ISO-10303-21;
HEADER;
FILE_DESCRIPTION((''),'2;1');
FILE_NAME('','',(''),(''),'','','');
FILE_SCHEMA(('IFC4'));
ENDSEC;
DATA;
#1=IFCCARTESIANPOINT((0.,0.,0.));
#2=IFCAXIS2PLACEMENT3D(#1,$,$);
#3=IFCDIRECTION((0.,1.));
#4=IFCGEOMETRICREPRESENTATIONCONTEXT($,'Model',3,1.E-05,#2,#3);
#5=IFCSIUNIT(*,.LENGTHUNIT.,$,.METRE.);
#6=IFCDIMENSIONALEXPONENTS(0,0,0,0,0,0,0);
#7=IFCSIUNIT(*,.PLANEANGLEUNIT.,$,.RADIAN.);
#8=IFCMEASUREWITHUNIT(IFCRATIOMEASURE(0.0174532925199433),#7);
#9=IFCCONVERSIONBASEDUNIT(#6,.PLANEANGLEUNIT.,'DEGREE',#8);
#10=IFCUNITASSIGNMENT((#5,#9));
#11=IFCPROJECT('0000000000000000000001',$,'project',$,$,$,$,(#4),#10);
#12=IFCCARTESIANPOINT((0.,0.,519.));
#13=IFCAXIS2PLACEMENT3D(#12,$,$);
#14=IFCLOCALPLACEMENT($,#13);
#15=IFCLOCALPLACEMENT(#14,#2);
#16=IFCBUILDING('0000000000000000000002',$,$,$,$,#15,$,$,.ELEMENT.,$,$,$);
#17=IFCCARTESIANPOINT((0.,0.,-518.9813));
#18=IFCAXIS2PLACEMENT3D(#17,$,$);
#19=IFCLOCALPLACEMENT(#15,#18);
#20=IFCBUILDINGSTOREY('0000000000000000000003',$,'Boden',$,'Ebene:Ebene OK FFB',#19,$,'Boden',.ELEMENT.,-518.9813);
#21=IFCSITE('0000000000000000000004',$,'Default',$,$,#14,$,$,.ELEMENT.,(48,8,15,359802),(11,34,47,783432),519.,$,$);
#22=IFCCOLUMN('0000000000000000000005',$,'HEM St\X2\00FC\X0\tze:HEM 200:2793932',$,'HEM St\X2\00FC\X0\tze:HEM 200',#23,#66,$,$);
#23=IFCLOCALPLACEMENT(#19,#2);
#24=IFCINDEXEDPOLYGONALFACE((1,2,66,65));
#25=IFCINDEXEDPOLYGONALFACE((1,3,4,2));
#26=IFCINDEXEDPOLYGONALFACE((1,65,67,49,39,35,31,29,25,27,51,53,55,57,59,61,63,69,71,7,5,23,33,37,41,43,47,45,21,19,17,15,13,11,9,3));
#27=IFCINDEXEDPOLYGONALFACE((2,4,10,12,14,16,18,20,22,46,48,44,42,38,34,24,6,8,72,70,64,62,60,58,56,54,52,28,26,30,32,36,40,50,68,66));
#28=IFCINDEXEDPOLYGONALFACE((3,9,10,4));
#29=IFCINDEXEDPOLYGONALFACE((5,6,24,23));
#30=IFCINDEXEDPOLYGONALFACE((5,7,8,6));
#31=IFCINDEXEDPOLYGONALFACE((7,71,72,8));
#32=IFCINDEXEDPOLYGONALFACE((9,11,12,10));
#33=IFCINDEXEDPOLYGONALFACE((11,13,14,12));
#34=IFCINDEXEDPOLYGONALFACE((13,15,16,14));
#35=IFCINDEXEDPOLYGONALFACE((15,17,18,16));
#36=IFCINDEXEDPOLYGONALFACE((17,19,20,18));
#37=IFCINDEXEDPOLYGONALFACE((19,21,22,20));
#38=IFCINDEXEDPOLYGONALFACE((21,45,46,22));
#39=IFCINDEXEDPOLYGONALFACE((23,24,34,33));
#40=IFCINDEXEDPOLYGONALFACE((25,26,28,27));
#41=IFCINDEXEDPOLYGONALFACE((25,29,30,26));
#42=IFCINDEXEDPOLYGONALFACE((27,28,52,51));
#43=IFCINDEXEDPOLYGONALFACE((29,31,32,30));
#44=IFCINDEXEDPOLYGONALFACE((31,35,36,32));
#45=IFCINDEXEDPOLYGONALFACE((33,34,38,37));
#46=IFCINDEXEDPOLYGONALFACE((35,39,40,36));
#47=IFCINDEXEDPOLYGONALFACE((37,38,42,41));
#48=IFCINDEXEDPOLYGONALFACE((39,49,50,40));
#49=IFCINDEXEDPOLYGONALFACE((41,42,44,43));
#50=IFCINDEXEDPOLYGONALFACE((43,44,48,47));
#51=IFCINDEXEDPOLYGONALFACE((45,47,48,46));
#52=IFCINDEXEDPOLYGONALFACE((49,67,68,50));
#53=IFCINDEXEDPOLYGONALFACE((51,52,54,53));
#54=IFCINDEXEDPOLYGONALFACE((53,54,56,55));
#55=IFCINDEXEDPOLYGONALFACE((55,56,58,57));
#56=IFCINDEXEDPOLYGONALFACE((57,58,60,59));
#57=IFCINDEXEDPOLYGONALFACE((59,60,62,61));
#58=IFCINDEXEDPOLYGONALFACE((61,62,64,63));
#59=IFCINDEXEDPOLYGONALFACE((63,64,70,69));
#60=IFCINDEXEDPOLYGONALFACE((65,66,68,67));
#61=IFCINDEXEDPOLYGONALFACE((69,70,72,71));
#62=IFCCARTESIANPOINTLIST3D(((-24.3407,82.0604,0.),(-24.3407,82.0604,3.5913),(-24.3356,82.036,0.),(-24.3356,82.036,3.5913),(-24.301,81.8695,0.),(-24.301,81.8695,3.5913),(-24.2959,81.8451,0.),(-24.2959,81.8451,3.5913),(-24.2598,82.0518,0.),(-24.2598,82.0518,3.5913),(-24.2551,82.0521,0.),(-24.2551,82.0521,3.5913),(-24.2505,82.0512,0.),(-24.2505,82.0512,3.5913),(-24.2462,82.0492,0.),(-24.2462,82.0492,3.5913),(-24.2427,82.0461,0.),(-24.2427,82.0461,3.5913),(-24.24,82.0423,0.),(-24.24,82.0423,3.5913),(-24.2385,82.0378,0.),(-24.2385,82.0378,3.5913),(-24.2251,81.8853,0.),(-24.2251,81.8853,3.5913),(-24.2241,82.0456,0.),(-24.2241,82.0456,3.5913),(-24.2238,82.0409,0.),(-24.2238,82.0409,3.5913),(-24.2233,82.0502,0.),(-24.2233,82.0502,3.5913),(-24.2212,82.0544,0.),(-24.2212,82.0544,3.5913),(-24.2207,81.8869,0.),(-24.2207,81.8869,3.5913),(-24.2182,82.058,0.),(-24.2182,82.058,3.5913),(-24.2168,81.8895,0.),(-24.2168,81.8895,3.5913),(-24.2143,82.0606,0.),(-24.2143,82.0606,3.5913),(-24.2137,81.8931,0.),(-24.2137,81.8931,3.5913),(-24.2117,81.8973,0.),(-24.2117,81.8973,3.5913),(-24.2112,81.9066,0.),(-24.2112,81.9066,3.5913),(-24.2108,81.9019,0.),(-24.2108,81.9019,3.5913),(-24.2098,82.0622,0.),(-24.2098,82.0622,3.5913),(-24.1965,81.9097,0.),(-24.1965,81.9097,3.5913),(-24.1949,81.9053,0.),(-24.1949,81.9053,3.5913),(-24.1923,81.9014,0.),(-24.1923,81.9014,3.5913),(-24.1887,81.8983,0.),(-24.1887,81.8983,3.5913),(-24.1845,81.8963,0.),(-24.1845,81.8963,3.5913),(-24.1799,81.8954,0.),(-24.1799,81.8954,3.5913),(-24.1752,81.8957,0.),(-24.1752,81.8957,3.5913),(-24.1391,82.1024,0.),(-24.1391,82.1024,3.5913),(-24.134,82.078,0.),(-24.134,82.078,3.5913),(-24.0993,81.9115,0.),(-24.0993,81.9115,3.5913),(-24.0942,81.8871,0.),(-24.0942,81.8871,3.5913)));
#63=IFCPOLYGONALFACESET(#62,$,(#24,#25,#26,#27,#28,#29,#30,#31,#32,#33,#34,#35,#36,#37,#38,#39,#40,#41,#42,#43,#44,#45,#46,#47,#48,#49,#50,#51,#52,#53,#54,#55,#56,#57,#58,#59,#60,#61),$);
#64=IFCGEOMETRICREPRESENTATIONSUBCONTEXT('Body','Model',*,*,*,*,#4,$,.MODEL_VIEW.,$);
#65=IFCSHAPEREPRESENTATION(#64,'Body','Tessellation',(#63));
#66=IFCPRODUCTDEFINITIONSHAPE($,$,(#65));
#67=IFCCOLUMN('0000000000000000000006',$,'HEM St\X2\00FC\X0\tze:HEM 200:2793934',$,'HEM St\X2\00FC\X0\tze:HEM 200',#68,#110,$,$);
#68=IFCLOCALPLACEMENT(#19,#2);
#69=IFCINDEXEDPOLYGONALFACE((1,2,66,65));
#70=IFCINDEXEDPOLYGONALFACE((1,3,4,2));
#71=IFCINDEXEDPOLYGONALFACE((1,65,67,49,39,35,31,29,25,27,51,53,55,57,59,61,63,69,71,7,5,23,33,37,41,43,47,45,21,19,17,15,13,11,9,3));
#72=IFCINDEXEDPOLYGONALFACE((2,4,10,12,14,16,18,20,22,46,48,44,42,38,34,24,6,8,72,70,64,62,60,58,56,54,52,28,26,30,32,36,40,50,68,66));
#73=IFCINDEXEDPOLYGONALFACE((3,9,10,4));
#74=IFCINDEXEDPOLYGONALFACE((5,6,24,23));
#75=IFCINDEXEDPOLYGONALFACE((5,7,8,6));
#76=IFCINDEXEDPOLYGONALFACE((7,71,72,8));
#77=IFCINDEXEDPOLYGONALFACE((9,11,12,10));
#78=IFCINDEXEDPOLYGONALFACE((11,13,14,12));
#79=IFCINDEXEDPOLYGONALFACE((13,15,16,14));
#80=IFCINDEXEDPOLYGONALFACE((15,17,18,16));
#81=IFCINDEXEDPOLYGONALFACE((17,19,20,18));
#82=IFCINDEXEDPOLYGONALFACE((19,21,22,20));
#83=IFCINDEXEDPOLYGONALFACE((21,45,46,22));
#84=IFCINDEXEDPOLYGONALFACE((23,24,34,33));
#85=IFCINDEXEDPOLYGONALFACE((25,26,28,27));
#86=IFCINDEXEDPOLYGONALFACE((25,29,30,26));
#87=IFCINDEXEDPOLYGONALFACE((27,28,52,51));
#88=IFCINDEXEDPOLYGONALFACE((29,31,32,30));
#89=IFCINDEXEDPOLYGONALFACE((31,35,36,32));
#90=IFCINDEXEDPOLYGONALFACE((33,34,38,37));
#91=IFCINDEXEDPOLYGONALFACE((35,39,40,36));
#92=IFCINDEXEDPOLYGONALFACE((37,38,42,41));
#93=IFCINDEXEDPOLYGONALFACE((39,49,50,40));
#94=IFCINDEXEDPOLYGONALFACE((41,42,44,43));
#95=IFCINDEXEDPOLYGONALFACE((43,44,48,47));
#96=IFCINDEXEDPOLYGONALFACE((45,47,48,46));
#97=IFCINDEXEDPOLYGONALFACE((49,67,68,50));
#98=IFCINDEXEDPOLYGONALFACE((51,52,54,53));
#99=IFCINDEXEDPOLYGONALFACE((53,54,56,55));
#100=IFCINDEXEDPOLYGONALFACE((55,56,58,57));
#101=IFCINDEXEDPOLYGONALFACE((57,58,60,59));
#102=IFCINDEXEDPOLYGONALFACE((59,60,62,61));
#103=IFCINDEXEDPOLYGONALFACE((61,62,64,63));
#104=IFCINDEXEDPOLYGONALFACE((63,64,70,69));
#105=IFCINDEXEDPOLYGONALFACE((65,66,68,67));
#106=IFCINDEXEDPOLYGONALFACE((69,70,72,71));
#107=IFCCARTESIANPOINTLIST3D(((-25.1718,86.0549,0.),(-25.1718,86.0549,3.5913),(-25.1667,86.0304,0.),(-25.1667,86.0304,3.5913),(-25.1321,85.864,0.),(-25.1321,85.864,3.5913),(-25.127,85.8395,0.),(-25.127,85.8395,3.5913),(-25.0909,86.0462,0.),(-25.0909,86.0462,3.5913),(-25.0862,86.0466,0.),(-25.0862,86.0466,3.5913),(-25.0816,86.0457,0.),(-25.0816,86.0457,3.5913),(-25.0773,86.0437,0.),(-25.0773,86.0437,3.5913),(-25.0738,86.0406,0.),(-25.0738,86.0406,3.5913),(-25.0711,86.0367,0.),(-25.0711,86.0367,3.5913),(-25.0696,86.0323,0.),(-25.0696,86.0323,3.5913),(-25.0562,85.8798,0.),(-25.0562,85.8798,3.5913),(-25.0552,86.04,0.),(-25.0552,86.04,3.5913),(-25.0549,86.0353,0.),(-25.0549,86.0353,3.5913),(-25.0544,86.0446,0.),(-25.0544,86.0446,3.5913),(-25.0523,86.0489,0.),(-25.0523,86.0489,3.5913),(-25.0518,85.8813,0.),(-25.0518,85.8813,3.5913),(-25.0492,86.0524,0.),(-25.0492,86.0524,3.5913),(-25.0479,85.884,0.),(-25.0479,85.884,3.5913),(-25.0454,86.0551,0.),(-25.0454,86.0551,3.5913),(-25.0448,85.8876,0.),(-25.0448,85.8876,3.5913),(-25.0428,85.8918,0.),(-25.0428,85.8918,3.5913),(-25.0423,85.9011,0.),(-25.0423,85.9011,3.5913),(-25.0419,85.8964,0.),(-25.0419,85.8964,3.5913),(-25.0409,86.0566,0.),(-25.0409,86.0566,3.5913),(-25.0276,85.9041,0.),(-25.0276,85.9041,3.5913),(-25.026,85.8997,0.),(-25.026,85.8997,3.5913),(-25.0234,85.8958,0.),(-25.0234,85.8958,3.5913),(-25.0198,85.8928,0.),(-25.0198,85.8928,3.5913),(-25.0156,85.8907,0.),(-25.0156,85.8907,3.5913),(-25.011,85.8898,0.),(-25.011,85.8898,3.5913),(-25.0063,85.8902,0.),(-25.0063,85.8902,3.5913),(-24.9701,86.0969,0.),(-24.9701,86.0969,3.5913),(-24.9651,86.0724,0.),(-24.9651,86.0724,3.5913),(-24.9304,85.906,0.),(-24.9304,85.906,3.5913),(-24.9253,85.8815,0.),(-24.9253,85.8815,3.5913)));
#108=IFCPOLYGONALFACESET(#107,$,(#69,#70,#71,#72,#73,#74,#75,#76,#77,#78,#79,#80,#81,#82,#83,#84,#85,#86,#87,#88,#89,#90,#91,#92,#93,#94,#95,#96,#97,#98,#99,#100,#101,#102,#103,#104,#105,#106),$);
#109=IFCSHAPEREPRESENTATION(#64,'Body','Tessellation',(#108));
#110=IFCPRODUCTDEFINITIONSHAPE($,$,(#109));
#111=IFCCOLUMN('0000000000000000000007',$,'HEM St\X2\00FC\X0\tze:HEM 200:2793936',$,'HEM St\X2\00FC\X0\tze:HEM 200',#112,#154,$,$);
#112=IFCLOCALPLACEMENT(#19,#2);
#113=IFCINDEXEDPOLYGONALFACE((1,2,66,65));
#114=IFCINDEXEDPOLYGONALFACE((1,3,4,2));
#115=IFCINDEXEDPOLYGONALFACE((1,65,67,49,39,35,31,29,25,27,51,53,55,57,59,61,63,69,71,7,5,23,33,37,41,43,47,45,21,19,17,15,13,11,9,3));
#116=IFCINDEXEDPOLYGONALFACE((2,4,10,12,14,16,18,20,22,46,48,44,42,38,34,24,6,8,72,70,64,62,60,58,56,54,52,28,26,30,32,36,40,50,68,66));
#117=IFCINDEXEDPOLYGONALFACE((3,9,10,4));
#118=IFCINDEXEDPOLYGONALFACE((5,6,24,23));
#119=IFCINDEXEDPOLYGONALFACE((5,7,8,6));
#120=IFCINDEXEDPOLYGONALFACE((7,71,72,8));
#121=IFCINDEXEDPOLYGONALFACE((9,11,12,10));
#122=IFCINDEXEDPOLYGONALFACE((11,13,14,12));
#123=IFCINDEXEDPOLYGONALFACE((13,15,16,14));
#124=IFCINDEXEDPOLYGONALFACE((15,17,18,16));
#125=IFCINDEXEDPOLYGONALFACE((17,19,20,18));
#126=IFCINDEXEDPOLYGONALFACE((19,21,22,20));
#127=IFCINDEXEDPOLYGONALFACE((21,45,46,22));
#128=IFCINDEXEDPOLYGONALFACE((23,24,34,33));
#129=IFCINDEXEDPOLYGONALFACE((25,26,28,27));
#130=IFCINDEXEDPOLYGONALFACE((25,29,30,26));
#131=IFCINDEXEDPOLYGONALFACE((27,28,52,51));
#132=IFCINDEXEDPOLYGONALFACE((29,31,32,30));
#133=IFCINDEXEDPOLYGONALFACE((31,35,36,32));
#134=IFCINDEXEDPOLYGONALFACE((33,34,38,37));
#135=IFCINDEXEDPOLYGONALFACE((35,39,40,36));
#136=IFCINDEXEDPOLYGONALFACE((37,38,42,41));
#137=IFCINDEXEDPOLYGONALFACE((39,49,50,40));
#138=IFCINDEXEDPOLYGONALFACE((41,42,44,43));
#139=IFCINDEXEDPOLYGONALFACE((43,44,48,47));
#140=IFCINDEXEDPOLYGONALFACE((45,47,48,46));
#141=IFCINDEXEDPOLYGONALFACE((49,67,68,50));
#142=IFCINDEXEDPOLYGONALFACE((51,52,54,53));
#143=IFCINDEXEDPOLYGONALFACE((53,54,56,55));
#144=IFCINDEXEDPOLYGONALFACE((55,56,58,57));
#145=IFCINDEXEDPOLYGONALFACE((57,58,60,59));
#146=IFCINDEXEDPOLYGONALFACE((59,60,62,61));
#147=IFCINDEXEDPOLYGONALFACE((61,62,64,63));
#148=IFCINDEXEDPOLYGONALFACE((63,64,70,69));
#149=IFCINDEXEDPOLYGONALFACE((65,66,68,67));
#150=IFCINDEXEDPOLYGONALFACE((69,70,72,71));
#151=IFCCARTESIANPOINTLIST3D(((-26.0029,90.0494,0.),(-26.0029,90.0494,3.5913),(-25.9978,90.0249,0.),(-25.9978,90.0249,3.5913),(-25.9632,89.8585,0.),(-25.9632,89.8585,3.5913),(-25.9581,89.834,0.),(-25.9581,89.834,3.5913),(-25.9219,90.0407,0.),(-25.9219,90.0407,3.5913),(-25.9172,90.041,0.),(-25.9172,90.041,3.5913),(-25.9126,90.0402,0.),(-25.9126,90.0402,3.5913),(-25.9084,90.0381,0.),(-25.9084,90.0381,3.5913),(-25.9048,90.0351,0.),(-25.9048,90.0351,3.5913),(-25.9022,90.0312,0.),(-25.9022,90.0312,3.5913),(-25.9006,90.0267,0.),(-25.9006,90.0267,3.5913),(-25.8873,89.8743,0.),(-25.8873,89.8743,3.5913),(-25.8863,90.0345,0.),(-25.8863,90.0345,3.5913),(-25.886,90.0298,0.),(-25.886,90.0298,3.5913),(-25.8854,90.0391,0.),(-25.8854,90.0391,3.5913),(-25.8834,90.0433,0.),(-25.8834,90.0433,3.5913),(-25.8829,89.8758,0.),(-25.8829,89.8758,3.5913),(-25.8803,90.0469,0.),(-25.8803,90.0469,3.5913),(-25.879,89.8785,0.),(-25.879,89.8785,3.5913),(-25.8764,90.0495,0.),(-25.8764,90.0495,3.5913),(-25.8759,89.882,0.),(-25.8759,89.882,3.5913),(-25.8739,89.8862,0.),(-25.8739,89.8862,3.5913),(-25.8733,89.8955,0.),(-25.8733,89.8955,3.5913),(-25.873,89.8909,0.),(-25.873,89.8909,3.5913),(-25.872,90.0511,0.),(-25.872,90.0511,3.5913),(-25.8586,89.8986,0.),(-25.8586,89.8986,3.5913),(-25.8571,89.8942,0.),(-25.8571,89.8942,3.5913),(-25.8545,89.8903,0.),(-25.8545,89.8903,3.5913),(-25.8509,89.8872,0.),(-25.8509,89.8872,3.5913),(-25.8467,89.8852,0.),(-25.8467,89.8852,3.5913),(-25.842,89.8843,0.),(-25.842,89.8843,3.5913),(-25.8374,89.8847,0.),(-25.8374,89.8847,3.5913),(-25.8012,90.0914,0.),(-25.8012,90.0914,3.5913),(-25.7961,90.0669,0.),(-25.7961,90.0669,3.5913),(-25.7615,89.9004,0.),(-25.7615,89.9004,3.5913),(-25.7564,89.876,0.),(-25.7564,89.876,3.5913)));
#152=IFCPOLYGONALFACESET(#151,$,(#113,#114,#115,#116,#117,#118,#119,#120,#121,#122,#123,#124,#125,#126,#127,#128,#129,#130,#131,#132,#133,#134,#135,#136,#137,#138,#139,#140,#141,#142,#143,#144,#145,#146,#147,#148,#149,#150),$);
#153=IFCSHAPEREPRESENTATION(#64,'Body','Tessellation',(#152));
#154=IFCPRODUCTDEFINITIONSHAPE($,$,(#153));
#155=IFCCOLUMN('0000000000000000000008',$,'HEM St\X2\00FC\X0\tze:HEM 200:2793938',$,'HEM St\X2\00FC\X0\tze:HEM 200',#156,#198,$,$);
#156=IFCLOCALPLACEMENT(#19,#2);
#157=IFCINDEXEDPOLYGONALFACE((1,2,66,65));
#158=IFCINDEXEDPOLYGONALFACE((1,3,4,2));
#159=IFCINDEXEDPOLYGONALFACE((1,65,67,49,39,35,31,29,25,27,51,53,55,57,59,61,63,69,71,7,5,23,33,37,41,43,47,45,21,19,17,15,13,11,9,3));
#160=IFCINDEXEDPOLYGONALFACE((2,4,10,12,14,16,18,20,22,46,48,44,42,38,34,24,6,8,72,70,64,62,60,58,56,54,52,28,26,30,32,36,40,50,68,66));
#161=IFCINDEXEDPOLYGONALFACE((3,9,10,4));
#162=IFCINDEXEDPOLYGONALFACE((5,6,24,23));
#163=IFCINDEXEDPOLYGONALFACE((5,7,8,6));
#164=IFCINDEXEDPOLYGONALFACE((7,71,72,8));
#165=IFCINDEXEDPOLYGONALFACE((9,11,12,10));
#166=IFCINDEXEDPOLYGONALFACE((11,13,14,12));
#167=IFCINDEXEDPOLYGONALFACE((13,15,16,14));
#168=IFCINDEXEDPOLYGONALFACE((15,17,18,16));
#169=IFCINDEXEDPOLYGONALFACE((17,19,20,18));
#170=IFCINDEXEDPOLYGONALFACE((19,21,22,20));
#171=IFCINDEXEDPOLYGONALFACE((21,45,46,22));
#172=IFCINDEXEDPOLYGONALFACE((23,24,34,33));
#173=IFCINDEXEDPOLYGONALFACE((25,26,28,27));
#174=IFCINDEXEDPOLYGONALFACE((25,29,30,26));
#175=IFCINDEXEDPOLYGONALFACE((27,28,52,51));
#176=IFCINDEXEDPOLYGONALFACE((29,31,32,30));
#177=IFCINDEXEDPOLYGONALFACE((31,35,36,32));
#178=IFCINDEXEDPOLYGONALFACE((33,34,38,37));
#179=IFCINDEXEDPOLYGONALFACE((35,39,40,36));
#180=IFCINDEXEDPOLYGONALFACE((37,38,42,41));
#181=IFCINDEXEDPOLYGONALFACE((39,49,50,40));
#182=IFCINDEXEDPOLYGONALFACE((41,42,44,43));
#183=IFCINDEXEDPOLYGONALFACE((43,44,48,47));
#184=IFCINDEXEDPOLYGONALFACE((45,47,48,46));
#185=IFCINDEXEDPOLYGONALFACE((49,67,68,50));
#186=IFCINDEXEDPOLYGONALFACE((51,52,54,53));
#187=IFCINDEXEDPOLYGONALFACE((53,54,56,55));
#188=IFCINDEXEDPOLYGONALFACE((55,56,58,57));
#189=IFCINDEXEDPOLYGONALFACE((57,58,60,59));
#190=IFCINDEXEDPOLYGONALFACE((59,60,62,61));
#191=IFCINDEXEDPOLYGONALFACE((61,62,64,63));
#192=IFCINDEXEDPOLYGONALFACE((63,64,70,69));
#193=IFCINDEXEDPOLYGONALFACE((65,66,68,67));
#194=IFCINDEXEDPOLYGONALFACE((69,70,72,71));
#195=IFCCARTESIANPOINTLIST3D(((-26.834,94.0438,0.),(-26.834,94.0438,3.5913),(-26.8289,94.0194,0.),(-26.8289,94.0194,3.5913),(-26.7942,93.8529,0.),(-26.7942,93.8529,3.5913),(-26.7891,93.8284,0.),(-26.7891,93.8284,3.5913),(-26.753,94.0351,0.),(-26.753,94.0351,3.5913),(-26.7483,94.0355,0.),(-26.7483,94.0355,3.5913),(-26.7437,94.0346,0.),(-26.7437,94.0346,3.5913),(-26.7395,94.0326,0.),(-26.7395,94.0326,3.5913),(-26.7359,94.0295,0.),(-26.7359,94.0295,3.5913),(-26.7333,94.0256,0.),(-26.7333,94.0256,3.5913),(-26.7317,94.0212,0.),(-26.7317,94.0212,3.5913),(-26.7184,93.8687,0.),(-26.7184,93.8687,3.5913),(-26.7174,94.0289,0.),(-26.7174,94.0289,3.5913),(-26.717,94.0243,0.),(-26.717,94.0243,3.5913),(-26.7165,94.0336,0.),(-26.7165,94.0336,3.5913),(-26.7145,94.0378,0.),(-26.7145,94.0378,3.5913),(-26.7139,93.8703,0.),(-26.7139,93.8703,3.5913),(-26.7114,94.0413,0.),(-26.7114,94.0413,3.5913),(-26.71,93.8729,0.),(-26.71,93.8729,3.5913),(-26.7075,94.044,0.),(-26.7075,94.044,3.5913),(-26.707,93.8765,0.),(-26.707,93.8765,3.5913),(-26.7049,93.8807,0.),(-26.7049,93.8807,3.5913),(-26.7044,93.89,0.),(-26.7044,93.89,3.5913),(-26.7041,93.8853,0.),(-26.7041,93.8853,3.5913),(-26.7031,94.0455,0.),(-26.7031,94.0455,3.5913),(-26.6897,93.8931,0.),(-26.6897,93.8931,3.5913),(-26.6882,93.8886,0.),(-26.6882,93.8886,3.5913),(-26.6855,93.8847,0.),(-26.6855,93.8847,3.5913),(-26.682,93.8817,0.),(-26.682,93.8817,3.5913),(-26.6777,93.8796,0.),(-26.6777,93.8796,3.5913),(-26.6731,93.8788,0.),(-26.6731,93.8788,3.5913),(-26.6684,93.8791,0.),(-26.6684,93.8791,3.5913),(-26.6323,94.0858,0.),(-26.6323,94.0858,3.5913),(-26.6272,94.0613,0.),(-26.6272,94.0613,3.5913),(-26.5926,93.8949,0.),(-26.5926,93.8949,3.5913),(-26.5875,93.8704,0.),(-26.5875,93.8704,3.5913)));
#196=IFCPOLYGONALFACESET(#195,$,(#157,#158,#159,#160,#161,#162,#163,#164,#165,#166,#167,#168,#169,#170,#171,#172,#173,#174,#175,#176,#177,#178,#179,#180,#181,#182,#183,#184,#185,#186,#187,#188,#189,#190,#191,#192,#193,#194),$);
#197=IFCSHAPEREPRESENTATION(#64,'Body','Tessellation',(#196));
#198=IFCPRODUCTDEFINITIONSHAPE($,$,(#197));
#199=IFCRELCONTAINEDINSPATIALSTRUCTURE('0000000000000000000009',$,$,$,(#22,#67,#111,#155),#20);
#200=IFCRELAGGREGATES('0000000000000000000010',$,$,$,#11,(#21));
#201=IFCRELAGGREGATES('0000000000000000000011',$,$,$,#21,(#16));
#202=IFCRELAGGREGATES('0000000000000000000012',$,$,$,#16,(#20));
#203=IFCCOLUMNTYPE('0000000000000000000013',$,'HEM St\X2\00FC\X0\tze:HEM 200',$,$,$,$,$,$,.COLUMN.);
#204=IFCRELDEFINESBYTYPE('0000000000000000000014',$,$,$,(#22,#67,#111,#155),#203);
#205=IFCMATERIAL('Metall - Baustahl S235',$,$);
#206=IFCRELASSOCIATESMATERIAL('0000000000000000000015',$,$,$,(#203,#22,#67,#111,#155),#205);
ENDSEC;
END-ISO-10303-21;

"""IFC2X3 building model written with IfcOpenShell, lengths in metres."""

from ifc_helpers import new_model, entity, si_unit, converted_unit, direction, frame, frame_2d, origin, place, context, subcontext, project, spatial, polyline, circle_curve, parameter, trimmed, segment, composite_curve, outline, extrude, source, transform, mapped, material, type_object, type_shapes, element, save


model = new_model("IFC2X3")

# Units and contexts
model_context = context("Model", 3, precision=1e-05, world=origin(), true_north=direction((0.0, 1.0)))
body_context = subcontext(model_context, "Body", "Model", "MODEL_VIEW")
ifc_project = project(units=[si_unit("LENGTHUNIT", "METRE"), converted_unit("PLANEANGLEUNIT", "DEGREE", entity("IfcRatioMeasure", 0.0174532925199433), si_unit("PLANEANGLEUNIT", "RADIAN"), dimensions=[0, 0, 0, 0, 0, 0, 0])], contexts=[model_context])

# Site, building, storey
site_placement = place(None, frame((0.0, 0.0, 519.0)))
site = spatial("IfcSite", under=ifc_project, at=site_placement, Name="Default", CompositionType="ELEMENT", RefLatitude=(48, 8, 15, 359802), RefLongitude=(11, 34, 47, 783432), RefElevation=519.0)
building_placement = place(site_placement, origin())
building = spatial("IfcBuilding", under=site, at=building_placement, CompositionType="ELEMENT")
storey_placement = place(building_placement, frame((0.0, 0.0, -518.9813)))
storey = spatial("IfcBuildingStorey", under=building, at=storey_placement, Name="Boden", ObjectType="Ebene:Ebene OK FFB", LongName="Boden", CompositionType="ELEMENT", Elevation=-518.9813)

# Columns
ifc_material = material(Name="Metall - Baustahl S235")
column_type = type_object("IfcColumnType", Name="HEM Stütze:HEM 200", PredefinedType="COLUMN", material=ifc_material)
shared_shape = source(origin(), body_context, "Body", "SweptSolid", [
    extrude(outline(composite_curve([segment(polyline([(0.085, -0.103), (0.11, -0.103)]), True, "CONTINUOUS"), segment(polyline([(0.11, -0.103), (0.11, 0.103)]), True, "CONTINUOUS"), segment(polyline([(0.11, 0.103), (0.085, 0.103)]), True, "CONTINUOUS"), segment(polyline([(0.085, 0.103), (0.085, 0.0255)]), True, "CONTINUOUS"), segment(trimmed(circle_curve(frame_2d((0.067, 0.0255), x_axis=(1.0, 0.0)), 0.018), [parameter(270.0)], [parameter(0.0)], True, "PARAMETER"), False, "CONTINUOUS"), segment(polyline([(0.067, 0.0075), (-0.067, 0.0075)]), True, "CONTINUOUS"), segment(trimmed(circle_curve(frame_2d((-0.067, 0.0255), x_axis=(0.0, -1.0)), 0.018), [parameter(270.0)], [parameter(0.0)], True, "PARAMETER"), False, "CONTINUOUS"), segment(polyline([(-0.085, 0.0255), (-0.085, 0.103)]), True, "CONTINUOUS"), segment(polyline([(-0.085, 0.103), (-0.11, 0.103)]), True, "CONTINUOUS"), segment(polyline([(-0.11, 0.103), (-0.11, -0.103)]), True, "CONTINUOUS"), segment(polyline([(-0.11, -0.103), (-0.085, -0.103)]), True, "CONTINUOUS"), segment(polyline([(-0.085, -0.103), (-0.085, -0.0255)]), True, "CONTINUOUS"), segment(trimmed(circle_curve(frame_2d((-0.067, -0.0255), x_axis=(-1.0, 0.0)), 0.018), [parameter(270.0)], [parameter(0.0)], True, "PARAMETER"), False, "CONTINUOUS"), segment(polyline([(-0.067, -0.0075), (0.067, -0.0075)]), True, "CONTINUOUS"), segment(trimmed(circle_curve(frame_2d((0.067, -0.0255), x_axis=(0.0, 1.0)), 0.018), [parameter(270.0)], [parameter(0.0)], True, "PARAMETER"), False, "CONTINUOUS"), segment(polyline([(0.085, -0.0255), (0.085, -0.103)]), True, "CONTINUOUS")], self_intersect=False)), frame((0.0, 0.0, -518.9813), z_axis=(0.0, 0.0, 1.0), x_axis=(0.0, -1.0, 0.0)), (0.0, 0.0, 1.0), 3.5913),
])
type_shapes(column_type, [shared_shape])
for number, where, z_axis, x_axis, name in (
    (1, (-24.2175, 81.9738, 518.9813), (0.0, 0.0, 1.0), (0.979008, 0.20382, 0.0), "HEM Stütze:HEM 200:2793932"),
    (2, (-25.0486, 85.9682, 518.9813), (0.0, 0.0, 1.0), (0.979008, 0.20382, 0.0), "HEM Stütze:HEM 200:2793934"),
    (3, (-25.8796, 89.9627, 518.9813), (0.0, 0.0, 1.0), (0.979008, 0.20382, 0.0), "HEM Stütze:HEM 200:2793936"),
    (4, (-26.7107, 93.9571, 518.9813), (0.0, 0.0, 1.0), (0.979008, 0.20382, 0.0), "HEM Stütze:HEM 200:2793938"),
):
    element("IfcColumn", number, at=place(storey_placement, frame(where, z_axis=z_axis, x_axis=x_axis)), inside=storey, type_object=column_type, material=ifc_material, Name=name, ObjectType="HEM Stütze:HEM 200", context=body_context, shape_type="MappedRepresentation", body=[
        mapped(shared_shape, transform((0.0, 0.0, 0.0), scale=1.0)),
    ])

save(model, "model.ifc")
